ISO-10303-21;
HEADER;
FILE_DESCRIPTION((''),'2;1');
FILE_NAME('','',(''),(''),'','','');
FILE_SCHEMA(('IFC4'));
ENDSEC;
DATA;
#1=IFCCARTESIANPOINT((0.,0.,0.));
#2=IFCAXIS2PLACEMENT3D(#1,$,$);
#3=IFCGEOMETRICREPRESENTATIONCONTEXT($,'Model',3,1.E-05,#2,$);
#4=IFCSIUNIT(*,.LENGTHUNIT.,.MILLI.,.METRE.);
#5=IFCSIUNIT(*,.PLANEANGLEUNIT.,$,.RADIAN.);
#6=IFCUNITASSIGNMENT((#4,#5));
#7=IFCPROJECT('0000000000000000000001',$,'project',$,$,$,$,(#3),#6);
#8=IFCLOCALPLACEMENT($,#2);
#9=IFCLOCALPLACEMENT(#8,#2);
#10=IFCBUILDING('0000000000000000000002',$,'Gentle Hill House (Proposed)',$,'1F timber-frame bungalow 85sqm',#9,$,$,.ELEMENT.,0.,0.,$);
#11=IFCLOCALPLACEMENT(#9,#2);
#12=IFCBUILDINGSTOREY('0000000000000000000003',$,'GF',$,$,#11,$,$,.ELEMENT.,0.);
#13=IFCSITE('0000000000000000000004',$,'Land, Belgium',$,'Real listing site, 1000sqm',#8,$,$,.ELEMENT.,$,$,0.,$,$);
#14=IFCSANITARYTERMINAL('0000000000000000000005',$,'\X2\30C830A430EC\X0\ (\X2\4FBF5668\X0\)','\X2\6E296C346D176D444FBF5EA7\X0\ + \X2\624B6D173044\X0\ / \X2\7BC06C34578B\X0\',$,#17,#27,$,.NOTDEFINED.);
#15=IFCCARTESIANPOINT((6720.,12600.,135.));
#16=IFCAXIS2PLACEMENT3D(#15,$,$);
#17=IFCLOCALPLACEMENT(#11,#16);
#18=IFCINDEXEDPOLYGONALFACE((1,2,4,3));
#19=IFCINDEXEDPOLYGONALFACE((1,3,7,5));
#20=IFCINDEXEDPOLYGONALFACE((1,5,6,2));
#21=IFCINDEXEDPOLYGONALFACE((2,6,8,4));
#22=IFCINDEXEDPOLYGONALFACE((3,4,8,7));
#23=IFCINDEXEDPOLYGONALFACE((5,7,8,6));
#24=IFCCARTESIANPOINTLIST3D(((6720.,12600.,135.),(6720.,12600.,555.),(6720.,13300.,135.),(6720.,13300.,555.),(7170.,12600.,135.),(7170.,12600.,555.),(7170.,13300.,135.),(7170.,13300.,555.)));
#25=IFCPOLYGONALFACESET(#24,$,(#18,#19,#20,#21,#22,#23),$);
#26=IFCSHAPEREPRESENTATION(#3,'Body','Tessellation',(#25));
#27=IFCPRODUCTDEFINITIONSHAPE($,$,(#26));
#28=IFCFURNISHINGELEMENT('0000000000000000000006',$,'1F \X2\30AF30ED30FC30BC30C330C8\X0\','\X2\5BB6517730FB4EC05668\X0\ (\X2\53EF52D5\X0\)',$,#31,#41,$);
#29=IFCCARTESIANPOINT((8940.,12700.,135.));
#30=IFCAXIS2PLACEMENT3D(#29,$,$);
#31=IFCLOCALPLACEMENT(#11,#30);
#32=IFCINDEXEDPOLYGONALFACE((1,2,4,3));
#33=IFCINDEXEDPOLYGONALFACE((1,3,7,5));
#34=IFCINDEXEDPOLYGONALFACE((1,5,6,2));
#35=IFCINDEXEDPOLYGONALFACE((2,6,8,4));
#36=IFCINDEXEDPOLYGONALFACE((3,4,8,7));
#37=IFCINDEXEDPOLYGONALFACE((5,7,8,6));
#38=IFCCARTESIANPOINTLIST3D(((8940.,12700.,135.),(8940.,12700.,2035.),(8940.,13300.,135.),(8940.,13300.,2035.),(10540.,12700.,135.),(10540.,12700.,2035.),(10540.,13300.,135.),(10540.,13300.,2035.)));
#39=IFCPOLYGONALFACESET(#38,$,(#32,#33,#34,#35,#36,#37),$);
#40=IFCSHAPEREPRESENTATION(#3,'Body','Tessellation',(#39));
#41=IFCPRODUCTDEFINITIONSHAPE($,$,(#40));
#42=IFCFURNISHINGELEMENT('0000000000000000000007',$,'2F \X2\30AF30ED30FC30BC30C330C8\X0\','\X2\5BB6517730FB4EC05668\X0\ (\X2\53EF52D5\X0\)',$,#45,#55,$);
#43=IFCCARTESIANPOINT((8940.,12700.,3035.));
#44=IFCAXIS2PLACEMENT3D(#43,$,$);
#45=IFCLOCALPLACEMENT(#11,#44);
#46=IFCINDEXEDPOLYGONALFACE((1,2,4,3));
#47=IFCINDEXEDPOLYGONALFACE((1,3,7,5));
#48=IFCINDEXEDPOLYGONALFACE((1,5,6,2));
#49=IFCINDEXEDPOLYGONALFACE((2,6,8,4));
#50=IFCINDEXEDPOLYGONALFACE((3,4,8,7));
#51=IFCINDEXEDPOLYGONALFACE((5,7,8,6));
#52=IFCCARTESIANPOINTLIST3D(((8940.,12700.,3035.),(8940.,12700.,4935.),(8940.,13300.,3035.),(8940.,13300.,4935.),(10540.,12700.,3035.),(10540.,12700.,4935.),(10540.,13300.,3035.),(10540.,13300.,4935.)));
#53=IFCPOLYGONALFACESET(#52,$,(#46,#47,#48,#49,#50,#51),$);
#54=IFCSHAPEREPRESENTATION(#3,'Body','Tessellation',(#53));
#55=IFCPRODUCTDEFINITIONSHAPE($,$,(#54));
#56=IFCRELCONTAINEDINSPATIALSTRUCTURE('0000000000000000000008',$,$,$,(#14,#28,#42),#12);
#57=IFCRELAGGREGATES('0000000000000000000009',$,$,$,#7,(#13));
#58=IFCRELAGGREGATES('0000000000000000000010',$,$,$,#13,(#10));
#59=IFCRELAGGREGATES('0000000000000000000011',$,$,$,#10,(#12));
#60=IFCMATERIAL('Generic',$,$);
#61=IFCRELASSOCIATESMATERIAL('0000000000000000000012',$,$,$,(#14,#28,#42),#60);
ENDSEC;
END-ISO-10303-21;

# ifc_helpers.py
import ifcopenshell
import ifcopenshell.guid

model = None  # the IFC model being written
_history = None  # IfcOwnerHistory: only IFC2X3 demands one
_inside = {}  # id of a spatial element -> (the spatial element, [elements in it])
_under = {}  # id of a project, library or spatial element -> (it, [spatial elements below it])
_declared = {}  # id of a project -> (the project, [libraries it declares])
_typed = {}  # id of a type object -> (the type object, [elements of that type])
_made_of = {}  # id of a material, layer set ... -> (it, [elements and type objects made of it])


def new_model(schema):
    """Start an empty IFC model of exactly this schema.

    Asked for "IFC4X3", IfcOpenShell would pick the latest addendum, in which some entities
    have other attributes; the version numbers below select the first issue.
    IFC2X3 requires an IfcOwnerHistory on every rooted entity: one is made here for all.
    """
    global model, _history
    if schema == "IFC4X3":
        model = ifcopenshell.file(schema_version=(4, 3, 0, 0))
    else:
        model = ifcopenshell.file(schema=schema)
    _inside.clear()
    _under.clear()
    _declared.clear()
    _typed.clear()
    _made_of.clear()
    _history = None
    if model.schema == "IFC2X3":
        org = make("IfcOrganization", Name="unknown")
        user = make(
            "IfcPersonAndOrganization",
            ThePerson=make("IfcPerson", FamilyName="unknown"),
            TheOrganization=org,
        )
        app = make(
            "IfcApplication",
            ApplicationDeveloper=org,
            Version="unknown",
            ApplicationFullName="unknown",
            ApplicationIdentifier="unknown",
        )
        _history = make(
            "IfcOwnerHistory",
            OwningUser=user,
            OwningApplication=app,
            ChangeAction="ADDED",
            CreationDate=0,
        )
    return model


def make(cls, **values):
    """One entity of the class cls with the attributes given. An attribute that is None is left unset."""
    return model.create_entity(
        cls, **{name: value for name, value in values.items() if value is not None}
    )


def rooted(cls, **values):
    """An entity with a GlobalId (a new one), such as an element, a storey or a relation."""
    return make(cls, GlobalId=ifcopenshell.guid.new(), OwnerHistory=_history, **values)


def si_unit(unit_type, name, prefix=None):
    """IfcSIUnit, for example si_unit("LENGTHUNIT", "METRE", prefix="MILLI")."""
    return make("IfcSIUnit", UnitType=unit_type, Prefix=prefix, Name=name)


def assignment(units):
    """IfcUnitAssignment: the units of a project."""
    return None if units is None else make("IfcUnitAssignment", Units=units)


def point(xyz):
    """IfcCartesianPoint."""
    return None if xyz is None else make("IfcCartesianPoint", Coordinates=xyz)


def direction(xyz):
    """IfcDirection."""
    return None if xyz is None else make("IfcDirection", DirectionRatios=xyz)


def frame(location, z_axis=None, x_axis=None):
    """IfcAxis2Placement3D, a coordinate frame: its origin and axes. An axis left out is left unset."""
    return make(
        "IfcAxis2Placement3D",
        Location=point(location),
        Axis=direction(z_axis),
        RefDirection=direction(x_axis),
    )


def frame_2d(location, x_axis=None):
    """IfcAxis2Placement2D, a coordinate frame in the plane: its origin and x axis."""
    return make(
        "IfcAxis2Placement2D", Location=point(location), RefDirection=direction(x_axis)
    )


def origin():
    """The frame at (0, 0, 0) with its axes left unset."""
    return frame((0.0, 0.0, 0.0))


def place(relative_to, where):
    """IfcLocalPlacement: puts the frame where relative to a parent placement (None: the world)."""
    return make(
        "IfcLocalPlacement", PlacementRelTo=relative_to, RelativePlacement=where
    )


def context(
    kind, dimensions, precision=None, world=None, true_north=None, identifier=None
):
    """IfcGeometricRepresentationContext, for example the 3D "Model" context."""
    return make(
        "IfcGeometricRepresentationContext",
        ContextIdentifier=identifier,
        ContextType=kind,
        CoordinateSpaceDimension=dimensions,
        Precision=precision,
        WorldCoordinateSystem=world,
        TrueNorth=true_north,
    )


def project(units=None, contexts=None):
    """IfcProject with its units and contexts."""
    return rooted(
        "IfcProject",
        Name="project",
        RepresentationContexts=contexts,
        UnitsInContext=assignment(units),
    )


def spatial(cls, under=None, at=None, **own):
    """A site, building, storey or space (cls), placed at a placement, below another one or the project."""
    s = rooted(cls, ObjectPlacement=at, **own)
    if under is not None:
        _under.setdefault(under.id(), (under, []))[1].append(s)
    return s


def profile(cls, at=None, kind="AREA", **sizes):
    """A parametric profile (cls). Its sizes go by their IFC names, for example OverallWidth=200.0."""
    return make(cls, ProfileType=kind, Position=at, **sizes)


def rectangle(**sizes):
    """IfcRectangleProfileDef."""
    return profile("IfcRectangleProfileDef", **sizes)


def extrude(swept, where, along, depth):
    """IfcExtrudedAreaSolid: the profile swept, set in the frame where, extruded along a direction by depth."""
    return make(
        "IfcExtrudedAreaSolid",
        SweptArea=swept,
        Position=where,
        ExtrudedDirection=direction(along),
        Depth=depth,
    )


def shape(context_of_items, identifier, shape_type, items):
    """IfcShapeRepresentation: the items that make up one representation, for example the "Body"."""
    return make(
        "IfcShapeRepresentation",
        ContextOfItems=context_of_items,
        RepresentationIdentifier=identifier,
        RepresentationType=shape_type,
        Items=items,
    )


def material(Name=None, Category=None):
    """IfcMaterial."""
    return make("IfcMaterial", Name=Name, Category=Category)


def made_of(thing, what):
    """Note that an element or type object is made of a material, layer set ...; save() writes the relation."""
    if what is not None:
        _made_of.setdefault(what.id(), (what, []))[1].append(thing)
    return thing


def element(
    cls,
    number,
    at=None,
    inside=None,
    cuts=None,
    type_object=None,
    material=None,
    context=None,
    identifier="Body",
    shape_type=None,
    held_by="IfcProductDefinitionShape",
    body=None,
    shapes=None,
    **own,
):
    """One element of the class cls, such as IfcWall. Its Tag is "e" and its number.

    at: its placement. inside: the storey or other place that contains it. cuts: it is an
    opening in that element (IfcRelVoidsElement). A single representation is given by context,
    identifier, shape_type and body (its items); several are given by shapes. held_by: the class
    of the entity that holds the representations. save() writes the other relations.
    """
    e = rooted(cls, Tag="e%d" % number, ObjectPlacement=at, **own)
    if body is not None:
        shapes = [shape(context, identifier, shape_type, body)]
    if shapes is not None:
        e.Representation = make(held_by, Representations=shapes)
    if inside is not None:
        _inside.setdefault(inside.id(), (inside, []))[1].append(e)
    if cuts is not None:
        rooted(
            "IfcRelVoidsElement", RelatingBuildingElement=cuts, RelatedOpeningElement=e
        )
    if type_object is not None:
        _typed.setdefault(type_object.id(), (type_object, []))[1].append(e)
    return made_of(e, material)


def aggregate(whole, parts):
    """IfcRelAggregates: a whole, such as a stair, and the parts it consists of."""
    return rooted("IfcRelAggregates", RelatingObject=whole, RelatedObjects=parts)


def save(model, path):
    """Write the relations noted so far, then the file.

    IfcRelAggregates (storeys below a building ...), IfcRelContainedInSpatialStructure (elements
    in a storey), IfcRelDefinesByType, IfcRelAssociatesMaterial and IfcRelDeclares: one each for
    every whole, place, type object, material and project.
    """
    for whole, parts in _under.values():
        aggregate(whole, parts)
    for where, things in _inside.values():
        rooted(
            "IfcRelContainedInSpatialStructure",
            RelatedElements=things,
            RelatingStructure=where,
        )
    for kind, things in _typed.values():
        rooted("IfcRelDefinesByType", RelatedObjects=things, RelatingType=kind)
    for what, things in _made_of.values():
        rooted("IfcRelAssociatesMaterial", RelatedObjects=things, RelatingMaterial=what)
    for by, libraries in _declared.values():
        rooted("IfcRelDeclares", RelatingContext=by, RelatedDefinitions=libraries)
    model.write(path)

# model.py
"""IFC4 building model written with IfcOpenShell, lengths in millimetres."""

from ifc_helpers import new_model, si_unit, frame, frame_2d, origin, place, context, project, spatial, rectangle, extrude, material, element, save


model = new_model("IFC4")

# Units and contexts
model_context = context("Model", 3, precision=1e-05, world=origin())
ifc_project = project(units=[si_unit("LENGTHUNIT", "METRE", prefix="MILLI"), si_unit("PLANEANGLEUNIT", "RADIAN")], contexts=[model_context])

# Site, building, storey
site_placement = place(None, origin())
site = spatial("IfcSite", under=ifc_project, at=site_placement, Name="Land, Belgium", ObjectType="Real listing site, 1000sqm", CompositionType="ELEMENT", RefElevation=0.0)
building_placement = place(site_placement, origin())
building = spatial("IfcBuilding", under=site, at=building_placement, Name="Gentle Hill House (Proposed)", ObjectType="1F timber-frame bungalow 85sqm", CompositionType="ELEMENT", ElevationOfRefHeight=0.0, ElevationOfTerrain=0.0)
storey_placement = place(building_placement, origin())
storey = spatial("IfcBuildingStorey", under=building, at=storey_placement, Name="GF", CompositionType="ELEMENT", Elevation=0.0)

# Sanitary terminal
ifc_material_1 = material(Name="Generic")
sanitary_terminal_1_placement = place(storey_placement, frame((6720.0, 12600.0, 135.0)))
element("IfcSanitaryTerminal", 1, at=sanitary_terminal_1_placement, inside=storey, material=ifc_material_1, Name="トイレ (便器)", Description="温水洗浄便座 + 手洗い / 節水型", PredefinedType="NOTDEFINED", context=model_context, shape_type="SweptSolid", body=[
    extrude(rectangle(XDim=450.0, YDim=700.0, at=frame_2d((225.0, 350.0))), frame((6720.0, 12600.0, 135.0)), (0.0, 0.0, 1.0), 420.0),
])

# Furnishing elements
furnishing_1_placement = place(storey_placement, frame((8940.0, 12700.0, 135.0)))
element("IfcFurnishingElement", 2, at=furnishing_1_placement, inside=storey, material=ifc_material_1, Name="1F クローゼット", Description="家具・什器 (可動)", context=model_context, shape_type="SweptSolid", body=[
    extrude(rectangle(XDim=1600.0, YDim=600.0, at=frame_2d((800.0, 300.0))), frame((8940.0, 12700.0, 135.0)), (0.0, 0.0, 1.0), 1900.0),
])
furnishing_2_placement = place(storey_placement, frame((8940.0, 12700.0, 3035.0)))
element("IfcFurnishingElement", 3, at=furnishing_2_placement, inside=storey, material=ifc_material_1, Name="2F クローゼット", Description="家具・什器 (可動)", context=model_context, shape_type="SweptSolid", body=[
    extrude(rectangle(XDim=1600.0, YDim=600.0, at=frame_2d((800.0, 300.0))), frame((8940.0, 12700.0, 3035.0)), (0.0, 0.0, 1.0), 1900.0),
])

save(model, "model.ifc")
